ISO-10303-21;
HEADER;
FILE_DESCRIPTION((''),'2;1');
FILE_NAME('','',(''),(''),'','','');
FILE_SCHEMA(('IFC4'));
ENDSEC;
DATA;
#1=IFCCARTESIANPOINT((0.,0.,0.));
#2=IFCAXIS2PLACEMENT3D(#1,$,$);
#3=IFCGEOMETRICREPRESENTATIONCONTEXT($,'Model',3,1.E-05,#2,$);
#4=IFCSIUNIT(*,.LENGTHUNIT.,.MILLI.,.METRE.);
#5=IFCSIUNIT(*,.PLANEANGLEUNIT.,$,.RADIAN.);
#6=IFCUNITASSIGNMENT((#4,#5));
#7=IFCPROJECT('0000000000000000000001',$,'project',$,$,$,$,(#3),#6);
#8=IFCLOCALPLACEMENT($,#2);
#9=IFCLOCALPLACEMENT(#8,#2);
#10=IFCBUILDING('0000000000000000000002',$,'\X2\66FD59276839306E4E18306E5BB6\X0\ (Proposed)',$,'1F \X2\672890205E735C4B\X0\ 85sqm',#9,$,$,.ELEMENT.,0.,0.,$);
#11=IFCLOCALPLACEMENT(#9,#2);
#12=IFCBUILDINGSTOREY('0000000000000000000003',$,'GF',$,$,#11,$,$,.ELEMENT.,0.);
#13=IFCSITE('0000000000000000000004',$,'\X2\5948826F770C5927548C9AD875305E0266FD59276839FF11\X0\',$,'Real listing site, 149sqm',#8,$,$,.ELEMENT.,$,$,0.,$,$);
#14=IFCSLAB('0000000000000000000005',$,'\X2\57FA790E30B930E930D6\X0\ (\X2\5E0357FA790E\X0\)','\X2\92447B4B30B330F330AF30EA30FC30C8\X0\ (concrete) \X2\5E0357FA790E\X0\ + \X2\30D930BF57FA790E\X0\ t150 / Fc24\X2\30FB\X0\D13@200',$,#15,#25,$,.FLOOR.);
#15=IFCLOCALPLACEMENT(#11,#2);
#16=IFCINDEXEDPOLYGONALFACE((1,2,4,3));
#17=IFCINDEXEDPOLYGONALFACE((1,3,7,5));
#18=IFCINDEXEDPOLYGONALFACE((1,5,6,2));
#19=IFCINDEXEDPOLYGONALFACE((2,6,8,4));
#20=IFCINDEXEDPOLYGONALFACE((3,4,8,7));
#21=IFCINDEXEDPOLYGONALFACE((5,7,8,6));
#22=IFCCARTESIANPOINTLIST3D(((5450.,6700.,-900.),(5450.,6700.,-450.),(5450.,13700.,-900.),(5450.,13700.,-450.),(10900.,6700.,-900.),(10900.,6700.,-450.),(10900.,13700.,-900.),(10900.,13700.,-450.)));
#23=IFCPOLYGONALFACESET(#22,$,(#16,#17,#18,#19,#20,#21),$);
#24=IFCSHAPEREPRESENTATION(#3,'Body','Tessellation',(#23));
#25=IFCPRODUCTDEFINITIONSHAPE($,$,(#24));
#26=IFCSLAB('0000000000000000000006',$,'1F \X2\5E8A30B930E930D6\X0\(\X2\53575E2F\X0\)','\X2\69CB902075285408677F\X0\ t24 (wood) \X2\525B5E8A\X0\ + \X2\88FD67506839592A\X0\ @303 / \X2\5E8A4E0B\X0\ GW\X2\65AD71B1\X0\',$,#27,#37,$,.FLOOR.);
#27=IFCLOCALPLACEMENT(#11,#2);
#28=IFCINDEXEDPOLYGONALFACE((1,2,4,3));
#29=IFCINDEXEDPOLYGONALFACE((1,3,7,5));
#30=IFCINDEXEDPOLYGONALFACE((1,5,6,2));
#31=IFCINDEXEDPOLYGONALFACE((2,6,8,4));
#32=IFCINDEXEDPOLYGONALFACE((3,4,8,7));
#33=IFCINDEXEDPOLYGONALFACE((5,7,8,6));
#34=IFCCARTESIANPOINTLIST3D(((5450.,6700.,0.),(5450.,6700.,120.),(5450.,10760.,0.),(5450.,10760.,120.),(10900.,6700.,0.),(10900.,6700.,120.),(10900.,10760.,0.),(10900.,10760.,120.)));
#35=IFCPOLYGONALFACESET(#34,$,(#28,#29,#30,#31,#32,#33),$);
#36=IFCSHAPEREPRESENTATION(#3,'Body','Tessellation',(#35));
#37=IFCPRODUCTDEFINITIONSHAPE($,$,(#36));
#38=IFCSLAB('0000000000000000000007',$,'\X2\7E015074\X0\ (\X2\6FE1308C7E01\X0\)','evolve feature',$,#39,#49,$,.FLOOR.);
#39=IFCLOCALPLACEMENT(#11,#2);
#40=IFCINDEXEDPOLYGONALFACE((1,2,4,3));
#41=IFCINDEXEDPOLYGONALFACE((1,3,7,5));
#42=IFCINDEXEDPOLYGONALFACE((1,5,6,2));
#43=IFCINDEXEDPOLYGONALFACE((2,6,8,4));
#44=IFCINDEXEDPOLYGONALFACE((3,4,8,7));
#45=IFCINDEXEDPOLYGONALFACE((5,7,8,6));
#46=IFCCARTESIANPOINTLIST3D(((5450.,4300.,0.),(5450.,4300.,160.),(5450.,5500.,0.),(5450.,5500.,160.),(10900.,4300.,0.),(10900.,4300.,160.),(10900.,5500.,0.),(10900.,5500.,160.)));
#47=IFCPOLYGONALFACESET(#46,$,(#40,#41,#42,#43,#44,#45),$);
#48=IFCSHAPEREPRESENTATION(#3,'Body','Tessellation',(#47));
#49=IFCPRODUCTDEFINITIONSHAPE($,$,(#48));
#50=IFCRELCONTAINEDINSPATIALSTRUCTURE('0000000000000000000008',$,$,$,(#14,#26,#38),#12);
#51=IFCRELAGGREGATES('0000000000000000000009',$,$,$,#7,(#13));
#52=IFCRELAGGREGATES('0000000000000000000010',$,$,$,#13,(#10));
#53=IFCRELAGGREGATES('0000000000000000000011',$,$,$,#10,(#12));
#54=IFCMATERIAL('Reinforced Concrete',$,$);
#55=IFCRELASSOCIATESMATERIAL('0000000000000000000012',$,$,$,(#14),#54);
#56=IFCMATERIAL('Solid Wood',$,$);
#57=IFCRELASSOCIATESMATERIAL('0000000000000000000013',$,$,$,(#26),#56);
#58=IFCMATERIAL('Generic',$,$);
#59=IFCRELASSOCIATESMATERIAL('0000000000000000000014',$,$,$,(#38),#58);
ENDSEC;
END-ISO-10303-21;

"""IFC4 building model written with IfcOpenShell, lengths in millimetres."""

from ifc_helpers import new_model, si_unit, frame, frame_2d, origin, place, context, project, spatial, rectangle, extrude, material, element, save


model = new_model("IFC4")

# Units and contexts
model_context = context("Model", 3, precision=1e-05, world=origin())
ifc_project = project(units=[si_unit("LENGTHUNIT", "METRE", prefix="MILLI"), si_unit("PLANEANGLEUNIT", "RADIAN")], contexts=[model_context])

# Site, building, storey
site_placement = place(None, origin())
site = spatial("IfcSite", under=ifc_project, at=site_placement, Name="奈良県大和高田市曽大根１", ObjectType="Real listing site, 149sqm", CompositionType="ELEMENT", RefElevation=0.0)
building_placement = place(site_placement, origin())
building = spatial("IfcBuilding", under=site, at=building_placement, Name="曽大根の丘の家 (Proposed)", ObjectType="1F 木造平屋 85sqm", CompositionType="ELEMENT", ElevationOfRefHeight=0.0, ElevationOfTerrain=0.0)
storey_placement = place(building_placement, origin())
storey = spatial("IfcBuildingStorey", under=building, at=storey_placement, Name="GF", CompositionType="ELEMENT", Elevation=0.0)

# Slabs
ifc_material_1 = material(Name="Reinforced Concrete")
slab_1_placement = place(storey_placement, frame((2725.0, 3350.0, -450.0)))
element("IfcSlab", 1, at=slab_1_placement, inside=storey, material=ifc_material_1, Name="基礎スラブ (布基礎)", Description="鉄筋コンクリート (concrete) 布基礎 + ベタ基礎 t150 / Fc24・D13@200", PredefinedType="FLOOR", context=model_context, shape_type="SweptSolid", body=[
    extrude(rectangle(XDim=5450.0, YDim=7000.0, at=frame_2d((2725.0, 3500.0))), frame((2725.0, 3350.0, -450.0)), (0.0, 0.0, 1.0), 450.0),
])
ifc_material_2 = material(Name="Solid Wood")
slab_2_placement = place(storey_placement, frame((2725.0, 3350.0, 0.0)))
element("IfcSlab", 2, at=slab_2_placement, inside=storey, material=ifc_material_2, Name="1F 床スラブ(南帯)", Description="構造用合板 t24 (wood) 剛床 + 製材根太 @303 / 床下 GW断熱", PredefinedType="FLOOR", context=model_context, shape_type="SweptSolid", body=[
    extrude(rectangle(XDim=5450.0, YDim=4060.0, at=frame_2d((2725.0, 2030.0))), frame((2725.0, 3350.0, 0.0)), (0.0, 0.0, 1.0), 120.0),
])
ifc_material_3 = material(Name="Generic")
slab_3_placement = place(storey_placement, frame((2725.0, 2150.0, 0.0)))
element("IfcSlab", 3, at=slab_3_placement, inside=storey, material=ifc_material_3, Name="縁側 (濡れ縁)", Description="evolve feature", PredefinedType="FLOOR", context=model_context, shape_type="SweptSolid", body=[
    extrude(rectangle(XDim=5450.0, YDim=1200.0, at=frame_2d((2725.0, 600.0))), frame((2725.0, 2150.0, 0.0)), (0.0, 0.0, 1.0), 160.0),
])

save(model, "model.ifc")
